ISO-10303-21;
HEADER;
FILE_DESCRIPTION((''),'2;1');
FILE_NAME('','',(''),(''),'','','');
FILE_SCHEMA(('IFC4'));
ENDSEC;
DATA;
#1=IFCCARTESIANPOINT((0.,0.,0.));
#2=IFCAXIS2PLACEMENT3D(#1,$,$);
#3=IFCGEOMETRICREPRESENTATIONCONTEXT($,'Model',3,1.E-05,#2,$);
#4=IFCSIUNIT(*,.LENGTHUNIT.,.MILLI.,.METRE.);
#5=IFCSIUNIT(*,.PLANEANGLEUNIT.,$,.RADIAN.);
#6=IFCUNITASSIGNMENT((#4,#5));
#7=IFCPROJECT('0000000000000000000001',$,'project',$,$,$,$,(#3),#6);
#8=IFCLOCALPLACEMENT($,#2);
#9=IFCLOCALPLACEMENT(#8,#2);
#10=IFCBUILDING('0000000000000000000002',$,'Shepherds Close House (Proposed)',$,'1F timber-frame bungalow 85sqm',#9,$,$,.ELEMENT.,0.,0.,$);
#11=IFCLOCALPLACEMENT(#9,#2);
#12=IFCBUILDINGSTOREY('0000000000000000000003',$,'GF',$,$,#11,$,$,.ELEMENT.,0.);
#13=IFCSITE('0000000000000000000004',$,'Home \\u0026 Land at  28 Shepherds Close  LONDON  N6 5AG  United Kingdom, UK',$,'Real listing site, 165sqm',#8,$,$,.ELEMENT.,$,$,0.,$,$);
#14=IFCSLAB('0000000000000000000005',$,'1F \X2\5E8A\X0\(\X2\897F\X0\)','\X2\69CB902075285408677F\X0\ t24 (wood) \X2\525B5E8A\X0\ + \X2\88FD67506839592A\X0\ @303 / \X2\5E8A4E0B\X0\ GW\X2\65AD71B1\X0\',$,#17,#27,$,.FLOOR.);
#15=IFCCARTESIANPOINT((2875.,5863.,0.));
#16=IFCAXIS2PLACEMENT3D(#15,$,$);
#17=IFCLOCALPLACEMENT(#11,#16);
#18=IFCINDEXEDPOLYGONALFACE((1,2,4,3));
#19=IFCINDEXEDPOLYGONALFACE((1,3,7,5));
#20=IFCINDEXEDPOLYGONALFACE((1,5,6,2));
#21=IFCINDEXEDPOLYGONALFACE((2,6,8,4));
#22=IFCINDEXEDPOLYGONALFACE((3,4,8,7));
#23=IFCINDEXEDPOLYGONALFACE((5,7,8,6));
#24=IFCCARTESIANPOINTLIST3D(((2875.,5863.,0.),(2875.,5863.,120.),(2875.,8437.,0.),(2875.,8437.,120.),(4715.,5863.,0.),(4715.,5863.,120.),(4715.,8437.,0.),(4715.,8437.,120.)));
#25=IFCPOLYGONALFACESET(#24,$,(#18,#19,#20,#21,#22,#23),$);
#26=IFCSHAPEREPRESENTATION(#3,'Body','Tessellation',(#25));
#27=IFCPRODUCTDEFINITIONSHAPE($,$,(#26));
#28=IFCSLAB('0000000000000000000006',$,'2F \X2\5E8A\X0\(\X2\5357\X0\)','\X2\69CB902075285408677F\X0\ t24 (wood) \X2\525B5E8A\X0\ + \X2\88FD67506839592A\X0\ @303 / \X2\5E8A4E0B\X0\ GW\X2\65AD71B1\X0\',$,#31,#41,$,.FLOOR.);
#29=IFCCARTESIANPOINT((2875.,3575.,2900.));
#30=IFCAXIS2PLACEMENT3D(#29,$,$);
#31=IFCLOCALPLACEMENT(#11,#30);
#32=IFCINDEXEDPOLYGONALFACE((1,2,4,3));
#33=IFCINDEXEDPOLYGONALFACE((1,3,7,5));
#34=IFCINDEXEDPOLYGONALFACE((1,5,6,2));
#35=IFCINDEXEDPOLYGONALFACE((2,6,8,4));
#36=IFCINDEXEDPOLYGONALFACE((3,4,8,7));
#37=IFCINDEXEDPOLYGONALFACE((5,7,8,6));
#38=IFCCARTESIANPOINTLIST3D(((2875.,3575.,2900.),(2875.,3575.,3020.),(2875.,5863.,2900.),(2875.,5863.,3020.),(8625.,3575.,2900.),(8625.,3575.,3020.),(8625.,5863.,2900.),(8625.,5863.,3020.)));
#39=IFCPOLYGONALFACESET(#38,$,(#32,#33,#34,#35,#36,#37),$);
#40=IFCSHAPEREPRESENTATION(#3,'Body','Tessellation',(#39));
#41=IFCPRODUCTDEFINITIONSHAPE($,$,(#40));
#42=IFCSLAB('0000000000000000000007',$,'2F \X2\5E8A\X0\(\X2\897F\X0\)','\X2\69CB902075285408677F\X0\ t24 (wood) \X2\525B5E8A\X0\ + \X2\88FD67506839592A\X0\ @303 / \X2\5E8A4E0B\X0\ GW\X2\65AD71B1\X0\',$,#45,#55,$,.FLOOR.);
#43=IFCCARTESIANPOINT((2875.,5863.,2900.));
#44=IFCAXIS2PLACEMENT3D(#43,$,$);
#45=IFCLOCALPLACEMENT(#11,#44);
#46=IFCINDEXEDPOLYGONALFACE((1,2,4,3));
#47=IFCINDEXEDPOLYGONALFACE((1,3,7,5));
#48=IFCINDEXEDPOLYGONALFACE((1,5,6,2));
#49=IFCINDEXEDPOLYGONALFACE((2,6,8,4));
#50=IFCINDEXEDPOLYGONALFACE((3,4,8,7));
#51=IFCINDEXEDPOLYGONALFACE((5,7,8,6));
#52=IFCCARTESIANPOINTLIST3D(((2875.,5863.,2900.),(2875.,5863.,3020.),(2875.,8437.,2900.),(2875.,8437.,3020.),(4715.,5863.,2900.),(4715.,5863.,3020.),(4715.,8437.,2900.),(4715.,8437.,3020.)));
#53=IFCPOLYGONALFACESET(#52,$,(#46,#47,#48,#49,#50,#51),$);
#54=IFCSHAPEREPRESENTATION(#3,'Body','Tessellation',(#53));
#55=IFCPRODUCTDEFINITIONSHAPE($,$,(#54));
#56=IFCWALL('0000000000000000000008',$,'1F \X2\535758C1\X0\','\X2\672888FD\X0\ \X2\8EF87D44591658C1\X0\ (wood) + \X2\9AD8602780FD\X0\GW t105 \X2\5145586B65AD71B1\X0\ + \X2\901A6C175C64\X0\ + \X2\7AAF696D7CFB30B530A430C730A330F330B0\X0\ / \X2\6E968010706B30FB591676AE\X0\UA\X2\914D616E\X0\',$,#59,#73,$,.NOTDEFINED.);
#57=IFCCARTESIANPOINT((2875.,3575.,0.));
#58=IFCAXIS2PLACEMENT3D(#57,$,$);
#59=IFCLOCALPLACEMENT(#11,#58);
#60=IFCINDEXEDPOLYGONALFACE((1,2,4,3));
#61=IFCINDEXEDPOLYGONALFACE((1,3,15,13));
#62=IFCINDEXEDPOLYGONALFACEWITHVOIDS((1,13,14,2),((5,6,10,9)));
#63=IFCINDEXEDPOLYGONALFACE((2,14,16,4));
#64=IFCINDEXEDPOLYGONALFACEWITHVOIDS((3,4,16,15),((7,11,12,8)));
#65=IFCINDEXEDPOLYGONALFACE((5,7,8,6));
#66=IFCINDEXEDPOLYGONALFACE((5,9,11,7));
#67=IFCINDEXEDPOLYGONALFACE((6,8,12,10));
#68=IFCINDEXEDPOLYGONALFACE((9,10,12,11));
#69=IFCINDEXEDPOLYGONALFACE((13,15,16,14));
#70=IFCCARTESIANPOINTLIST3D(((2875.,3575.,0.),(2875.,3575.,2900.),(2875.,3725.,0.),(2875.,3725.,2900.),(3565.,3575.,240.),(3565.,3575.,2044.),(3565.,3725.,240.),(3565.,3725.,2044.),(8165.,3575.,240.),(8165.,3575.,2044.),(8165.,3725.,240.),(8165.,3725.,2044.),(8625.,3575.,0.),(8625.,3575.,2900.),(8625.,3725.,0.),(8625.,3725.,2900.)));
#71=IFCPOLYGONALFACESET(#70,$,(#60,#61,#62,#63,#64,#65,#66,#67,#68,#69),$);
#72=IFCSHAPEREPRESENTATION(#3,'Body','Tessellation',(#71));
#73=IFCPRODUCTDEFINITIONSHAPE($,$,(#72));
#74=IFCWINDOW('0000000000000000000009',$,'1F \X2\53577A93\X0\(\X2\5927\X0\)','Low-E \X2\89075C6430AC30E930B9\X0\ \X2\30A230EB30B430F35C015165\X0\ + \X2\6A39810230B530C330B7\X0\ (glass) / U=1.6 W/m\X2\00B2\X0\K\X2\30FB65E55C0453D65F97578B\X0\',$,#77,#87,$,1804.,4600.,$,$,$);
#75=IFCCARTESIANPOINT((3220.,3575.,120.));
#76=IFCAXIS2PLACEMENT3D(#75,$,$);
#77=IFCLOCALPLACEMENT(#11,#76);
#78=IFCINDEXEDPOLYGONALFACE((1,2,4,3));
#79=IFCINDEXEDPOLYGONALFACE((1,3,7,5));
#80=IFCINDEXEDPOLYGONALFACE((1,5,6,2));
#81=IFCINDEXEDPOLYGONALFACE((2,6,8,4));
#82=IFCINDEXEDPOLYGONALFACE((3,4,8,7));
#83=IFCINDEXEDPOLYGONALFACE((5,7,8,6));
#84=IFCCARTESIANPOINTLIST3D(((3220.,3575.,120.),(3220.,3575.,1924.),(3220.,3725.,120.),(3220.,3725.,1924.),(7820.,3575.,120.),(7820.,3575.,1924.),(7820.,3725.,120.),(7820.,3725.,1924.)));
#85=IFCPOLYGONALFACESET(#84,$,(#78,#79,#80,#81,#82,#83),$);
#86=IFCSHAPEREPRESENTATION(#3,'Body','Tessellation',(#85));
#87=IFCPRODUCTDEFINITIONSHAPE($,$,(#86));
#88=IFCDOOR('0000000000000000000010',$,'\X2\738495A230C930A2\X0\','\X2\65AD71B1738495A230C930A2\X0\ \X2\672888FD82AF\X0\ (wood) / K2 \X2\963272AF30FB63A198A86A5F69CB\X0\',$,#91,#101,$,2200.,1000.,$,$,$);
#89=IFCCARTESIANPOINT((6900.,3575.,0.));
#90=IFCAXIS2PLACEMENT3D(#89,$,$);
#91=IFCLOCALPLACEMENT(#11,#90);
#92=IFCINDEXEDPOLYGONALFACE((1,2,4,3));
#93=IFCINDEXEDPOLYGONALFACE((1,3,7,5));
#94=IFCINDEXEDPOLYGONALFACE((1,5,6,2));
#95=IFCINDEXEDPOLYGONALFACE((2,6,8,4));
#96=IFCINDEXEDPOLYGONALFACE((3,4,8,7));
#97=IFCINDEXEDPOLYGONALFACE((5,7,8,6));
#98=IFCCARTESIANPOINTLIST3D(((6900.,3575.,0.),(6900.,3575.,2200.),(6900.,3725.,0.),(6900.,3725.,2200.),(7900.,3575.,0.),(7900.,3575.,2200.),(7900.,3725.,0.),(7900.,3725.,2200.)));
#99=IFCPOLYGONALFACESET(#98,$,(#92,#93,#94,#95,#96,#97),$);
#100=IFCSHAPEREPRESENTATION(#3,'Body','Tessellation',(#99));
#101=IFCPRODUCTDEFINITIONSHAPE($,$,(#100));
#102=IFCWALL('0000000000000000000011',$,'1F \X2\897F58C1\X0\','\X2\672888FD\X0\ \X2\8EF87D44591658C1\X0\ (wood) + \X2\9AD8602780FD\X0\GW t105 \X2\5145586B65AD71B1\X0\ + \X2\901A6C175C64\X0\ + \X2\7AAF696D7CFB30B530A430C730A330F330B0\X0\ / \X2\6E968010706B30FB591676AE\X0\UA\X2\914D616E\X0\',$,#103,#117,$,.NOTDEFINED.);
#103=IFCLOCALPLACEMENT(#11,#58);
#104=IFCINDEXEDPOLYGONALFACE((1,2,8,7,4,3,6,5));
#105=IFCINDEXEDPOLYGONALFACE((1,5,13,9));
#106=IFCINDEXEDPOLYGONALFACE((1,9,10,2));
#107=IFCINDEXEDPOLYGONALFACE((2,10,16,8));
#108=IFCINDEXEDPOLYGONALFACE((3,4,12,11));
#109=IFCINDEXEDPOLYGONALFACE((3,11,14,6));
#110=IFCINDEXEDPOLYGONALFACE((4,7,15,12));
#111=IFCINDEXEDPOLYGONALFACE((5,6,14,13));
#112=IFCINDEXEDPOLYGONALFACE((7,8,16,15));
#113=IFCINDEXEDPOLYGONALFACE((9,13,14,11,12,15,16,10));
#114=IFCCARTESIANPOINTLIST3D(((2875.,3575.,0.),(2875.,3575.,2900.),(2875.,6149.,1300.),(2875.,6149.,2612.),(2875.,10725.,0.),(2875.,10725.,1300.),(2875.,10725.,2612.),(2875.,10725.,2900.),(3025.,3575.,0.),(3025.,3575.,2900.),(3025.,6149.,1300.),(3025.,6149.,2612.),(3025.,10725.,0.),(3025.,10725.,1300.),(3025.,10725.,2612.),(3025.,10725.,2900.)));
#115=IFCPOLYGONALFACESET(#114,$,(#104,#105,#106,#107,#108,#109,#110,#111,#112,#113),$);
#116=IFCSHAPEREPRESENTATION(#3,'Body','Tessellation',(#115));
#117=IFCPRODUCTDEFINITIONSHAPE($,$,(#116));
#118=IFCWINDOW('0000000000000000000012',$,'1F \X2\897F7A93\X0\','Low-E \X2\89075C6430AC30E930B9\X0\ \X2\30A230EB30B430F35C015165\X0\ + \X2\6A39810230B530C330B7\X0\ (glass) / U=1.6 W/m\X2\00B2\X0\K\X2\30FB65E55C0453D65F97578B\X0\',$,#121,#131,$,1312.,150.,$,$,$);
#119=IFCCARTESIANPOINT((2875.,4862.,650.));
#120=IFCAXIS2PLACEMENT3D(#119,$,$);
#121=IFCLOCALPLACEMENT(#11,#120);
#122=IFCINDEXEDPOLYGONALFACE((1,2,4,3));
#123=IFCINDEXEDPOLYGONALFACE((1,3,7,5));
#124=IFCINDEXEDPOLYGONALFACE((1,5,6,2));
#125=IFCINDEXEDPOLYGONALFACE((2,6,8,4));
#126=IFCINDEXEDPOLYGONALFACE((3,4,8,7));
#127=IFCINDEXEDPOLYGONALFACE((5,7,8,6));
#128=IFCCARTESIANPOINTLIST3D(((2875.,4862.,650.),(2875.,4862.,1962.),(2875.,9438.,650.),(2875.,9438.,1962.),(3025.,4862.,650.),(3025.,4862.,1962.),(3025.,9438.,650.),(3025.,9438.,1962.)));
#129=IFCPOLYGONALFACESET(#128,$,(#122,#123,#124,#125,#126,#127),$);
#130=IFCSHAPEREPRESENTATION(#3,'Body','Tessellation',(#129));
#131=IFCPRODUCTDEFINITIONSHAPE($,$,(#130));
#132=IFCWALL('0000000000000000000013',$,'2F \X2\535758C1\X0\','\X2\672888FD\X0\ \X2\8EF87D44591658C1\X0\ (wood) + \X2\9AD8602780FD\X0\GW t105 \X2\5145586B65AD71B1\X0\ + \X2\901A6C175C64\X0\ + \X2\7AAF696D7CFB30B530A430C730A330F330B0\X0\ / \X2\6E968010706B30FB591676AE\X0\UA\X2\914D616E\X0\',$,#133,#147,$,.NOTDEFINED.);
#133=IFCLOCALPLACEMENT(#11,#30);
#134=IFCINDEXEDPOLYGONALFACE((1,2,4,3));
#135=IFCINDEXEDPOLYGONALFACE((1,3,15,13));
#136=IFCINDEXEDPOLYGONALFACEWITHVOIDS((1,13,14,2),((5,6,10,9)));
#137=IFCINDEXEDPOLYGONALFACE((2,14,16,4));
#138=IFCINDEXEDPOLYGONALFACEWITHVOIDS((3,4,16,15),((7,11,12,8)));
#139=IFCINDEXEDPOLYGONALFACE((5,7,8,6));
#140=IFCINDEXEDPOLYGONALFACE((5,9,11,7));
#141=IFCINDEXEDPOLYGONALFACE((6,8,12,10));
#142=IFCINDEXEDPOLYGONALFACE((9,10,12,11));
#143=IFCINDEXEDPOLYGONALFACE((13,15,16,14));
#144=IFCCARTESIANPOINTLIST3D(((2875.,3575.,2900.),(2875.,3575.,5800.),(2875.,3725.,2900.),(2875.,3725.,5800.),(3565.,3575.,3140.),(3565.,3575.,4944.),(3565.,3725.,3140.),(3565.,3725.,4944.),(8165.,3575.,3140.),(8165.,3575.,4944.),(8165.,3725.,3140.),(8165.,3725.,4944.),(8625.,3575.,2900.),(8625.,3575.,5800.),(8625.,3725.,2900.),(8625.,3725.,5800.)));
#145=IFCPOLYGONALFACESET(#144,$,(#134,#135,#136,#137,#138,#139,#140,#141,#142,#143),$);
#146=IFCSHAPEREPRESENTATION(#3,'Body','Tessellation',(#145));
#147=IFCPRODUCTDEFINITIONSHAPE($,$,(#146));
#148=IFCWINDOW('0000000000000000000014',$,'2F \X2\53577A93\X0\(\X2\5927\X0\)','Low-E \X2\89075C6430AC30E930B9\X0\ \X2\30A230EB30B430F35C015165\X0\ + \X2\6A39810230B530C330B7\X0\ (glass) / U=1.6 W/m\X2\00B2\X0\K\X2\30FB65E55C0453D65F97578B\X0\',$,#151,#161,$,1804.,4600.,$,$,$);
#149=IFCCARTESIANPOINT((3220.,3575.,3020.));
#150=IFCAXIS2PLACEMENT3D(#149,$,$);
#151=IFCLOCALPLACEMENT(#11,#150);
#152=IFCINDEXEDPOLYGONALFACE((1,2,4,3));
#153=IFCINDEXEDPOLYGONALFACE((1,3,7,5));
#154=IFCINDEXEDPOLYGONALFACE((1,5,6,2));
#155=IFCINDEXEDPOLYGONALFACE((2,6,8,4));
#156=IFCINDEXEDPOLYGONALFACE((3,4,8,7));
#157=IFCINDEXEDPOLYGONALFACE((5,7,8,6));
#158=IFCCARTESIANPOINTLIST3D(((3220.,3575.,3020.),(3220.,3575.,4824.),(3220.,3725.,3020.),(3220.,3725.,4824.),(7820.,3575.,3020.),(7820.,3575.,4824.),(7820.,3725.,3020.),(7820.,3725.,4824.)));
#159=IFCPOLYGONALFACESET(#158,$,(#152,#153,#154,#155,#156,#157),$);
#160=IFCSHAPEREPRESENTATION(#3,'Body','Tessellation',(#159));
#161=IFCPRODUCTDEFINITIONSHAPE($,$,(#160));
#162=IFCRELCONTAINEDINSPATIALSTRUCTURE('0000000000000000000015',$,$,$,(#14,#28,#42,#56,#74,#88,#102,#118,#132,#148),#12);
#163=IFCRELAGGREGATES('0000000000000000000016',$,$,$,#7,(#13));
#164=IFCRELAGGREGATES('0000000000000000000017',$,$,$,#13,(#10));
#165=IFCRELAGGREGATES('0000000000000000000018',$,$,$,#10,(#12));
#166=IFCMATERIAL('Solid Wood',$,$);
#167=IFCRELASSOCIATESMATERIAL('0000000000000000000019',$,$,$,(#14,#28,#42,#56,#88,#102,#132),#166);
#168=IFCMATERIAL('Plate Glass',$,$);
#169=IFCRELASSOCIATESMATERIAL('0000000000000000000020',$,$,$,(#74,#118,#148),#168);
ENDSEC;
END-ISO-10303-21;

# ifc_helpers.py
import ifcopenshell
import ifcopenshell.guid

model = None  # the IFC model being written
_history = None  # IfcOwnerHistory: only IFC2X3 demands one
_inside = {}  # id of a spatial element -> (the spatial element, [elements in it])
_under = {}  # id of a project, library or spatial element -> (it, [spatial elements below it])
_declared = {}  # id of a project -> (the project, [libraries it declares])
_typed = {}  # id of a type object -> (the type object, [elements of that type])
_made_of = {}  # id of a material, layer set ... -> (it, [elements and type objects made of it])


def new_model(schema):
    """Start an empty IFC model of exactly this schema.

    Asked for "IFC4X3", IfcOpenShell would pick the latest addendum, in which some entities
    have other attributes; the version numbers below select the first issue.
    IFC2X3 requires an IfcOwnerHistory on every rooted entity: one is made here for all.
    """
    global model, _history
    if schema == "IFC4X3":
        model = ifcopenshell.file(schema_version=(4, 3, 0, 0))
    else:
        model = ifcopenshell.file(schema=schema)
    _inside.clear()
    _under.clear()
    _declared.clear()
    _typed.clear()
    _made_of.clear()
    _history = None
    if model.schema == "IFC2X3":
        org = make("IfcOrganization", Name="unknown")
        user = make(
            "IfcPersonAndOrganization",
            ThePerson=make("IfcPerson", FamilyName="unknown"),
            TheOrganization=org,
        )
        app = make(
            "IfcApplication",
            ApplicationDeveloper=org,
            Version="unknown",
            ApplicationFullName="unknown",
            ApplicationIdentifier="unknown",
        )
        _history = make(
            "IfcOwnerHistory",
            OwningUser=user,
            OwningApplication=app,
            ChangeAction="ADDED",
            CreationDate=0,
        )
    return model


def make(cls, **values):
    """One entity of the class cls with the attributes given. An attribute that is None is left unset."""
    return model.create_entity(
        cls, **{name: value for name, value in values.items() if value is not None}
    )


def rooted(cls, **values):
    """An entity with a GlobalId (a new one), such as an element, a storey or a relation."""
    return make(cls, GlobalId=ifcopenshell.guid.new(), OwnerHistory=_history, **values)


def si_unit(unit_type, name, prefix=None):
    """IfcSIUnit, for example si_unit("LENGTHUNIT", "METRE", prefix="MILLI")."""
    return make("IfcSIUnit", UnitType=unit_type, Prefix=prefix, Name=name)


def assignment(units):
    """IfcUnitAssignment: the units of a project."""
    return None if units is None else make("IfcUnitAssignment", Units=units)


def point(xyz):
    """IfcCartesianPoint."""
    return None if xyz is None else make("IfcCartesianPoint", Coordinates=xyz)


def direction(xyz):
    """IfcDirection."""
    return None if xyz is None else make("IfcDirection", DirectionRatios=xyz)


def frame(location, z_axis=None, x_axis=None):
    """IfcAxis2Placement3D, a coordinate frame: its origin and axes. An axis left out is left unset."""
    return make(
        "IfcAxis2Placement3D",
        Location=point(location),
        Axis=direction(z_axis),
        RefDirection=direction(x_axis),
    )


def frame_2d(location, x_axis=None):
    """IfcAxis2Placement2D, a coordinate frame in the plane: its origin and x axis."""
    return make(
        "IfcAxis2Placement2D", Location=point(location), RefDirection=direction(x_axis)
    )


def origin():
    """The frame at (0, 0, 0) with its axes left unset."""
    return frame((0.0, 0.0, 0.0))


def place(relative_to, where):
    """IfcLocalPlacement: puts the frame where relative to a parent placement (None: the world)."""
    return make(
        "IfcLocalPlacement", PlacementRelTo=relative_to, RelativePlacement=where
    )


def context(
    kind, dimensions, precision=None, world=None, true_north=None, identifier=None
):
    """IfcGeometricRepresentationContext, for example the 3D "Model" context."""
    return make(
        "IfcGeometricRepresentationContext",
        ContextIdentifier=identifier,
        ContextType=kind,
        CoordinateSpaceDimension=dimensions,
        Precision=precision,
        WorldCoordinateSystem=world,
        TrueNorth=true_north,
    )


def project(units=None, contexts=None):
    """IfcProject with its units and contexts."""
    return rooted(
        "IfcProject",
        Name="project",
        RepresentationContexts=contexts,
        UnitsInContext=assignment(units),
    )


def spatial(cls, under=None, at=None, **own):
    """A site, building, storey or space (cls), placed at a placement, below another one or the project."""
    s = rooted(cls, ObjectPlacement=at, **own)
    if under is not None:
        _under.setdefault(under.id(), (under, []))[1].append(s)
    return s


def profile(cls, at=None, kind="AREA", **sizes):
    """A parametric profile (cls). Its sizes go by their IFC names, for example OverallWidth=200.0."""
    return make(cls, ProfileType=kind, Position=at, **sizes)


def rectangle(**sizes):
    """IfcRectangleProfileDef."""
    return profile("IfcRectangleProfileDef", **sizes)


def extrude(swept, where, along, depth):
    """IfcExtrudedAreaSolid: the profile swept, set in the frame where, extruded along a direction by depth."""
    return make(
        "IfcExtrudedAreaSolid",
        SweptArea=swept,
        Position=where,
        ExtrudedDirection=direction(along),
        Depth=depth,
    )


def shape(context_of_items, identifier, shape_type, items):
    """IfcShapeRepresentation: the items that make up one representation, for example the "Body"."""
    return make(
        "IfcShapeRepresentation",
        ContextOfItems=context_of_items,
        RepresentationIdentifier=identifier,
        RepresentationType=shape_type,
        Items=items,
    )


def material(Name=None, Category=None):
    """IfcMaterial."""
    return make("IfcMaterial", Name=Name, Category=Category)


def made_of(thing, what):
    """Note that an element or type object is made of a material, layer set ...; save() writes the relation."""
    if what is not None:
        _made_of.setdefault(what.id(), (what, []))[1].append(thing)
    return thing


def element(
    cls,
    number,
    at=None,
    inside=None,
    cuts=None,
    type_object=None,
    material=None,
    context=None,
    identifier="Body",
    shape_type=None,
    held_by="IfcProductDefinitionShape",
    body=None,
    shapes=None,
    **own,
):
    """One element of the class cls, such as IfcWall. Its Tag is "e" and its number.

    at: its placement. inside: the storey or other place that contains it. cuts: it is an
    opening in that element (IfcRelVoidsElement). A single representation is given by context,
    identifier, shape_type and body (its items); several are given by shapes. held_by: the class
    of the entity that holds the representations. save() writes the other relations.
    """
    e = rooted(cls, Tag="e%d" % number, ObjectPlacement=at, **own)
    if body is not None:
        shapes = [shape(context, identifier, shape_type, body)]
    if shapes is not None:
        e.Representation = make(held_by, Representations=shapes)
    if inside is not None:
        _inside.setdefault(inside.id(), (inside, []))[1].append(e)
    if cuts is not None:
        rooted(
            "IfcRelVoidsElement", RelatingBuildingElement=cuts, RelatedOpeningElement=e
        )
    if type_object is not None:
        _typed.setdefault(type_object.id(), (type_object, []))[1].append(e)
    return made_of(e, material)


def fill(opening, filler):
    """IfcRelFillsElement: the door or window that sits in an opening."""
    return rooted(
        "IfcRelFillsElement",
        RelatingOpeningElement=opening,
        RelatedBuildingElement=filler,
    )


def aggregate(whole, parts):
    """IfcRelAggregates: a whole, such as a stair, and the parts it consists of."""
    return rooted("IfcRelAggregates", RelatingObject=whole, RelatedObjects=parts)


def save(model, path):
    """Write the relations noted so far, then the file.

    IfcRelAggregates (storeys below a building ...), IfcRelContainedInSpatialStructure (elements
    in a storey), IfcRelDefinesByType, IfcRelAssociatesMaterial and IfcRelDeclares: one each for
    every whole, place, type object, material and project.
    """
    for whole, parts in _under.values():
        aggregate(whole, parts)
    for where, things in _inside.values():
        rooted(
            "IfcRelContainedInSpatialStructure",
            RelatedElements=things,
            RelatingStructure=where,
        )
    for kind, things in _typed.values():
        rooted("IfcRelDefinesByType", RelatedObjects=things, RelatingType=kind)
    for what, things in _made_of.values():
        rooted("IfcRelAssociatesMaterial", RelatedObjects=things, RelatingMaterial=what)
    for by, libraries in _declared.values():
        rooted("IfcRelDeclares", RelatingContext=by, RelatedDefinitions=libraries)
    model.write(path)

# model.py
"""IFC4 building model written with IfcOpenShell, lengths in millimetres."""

from ifc_helpers import new_model, si_unit, frame, frame_2d, origin, place, context, project, spatial, rectangle, extrude, material, element, fill, save


model = new_model("IFC4")

# Units and contexts
model_context = context("Model", 3, precision=1e-05, world=origin())
ifc_project = project(units=[si_unit("LENGTHUNIT", "METRE", prefix="MILLI"), si_unit("PLANEANGLEUNIT", "RADIAN")], contexts=[model_context])

# Site, building, storey
site_placement = place(None, origin())
site = spatial("IfcSite", under=ifc_project, at=site_placement, Name="Home \\u0026 Land at  28 Shepherds Close  LONDON  N6 5AG  United Kingdom, UK", ObjectType="Real listing site, 165sqm", CompositionType="ELEMENT", RefElevation=0.0)
building_placement = place(site_placement, origin())
building = spatial("IfcBuilding", under=site, at=building_placement, Name="Shepherds Close House (Proposed)", ObjectType="1F timber-frame bungalow 85sqm", CompositionType="ELEMENT", ElevationOfRefHeight=0.0, ElevationOfTerrain=0.0)
storey_placement = place(building_placement, origin())
storey = spatial("IfcBuildingStorey", under=building, at=storey_placement, Name="GF", CompositionType="ELEMENT", Elevation=0.0)

# Slabs
ifc_material_1 = material(Name="Solid Wood")
slab_1_placement = place(storey_placement, frame((2875.0, 5863.0, 0.0)))
element("IfcSlab", 1, at=slab_1_placement, inside=storey, material=ifc_material_1, Name="1F 床(西)", Description="構造用合板 t24 (wood) 剛床 + 製材根太 @303 / 床下 GW断熱", PredefinedType="FLOOR", context=model_context, shape_type="SweptSolid", body=[
    extrude(rectangle(XDim=1840.0, YDim=2574.0, at=frame_2d((920.0, 1287.0))), frame((2875.0, 5863.0, 0.0)), (0.0, 0.0, 1.0), 120.0),
])
slab_2_placement = place(storey_placement, frame((2875.0, 3575.0, 2900.0)))
element("IfcSlab", 2, at=slab_2_placement, inside=storey, material=ifc_material_1, Name="2F 床(南)", Description="構造用合板 t24 (wood) 剛床 + 製材根太 @303 / 床下 GW断熱", PredefinedType="FLOOR", context=model_context, shape_type="SweptSolid", body=[
    extrude(rectangle(XDim=5750.0, YDim=2288.0, at=frame_2d((2875.0, 1144.0))), frame((2875.0, 3575.0, 2900.0)), (0.0, 0.0, 1.0), 120.0),
])
slab_3_placement = place(storey_placement, frame((2875.0, 5863.0, 2900.0)))
element("IfcSlab", 3, at=slab_3_placement, inside=storey, material=ifc_material_1, Name="2F 床(西)", Description="構造用合板 t24 (wood) 剛床 + 製材根太 @303 / 床下 GW断熱", PredefinedType="FLOOR", context=model_context, shape_type="SweptSolid", body=[
    extrude(rectangle(XDim=1840.0, YDim=2574.0, at=frame_2d((920.0, 1287.0))), frame((2875.0, 5863.0, 2900.0)), (0.0, 0.0, 1.0), 120.0),
])

# Wall, openings, window, door
wall_1_placement = place(storey_placement, frame((2875.0, 3575.0, 0.0)))
wall_1 = element("IfcWall", 4, at=wall_1_placement, inside=storey, material=ifc_material_1, Name="1F 南壁", Description="木製 軸組外壁 (wood) + 高性能GW t105 充填断熱 + 通気層 + 窯業系サイディング / 準耐火・外皮UA配慮", PredefinedType="NOTDEFINED", context=model_context, shape_type="SweptSolid", body=[
    extrude(rectangle(XDim=5750.0, YDim=150.0, at=frame_2d((2875.0, 75.0))), frame((2875.0, 3575.0, 0.0)), (0.0, 0.0, 1.0), 2900.0),
])
opening_1_placement = place(storey_placement, frame((3220.0, 3575.0, 120.0)))
opening_1 = element("IfcOpeningElement", 5, at=opening_1_placement, cuts=wall_1, PredefinedType="NOTDEFINED", context=model_context, shape_type="SweptSolid", body=[
    extrude(rectangle(XDim=4600.0, YDim=150.0, at=frame_2d((2300.0, 75.0))), frame((3220.0, 3575.0, 120.0)), (0.0, 0.0, 1.0), 1804.0),
])
opening_2_placement = place(storey_placement, frame((6900.0, 3575.0, 0.0)))
opening_2 = element("IfcOpeningElement", 6, at=opening_2_placement, cuts=wall_1, PredefinedType="NOTDEFINED", context=model_context, shape_type="SweptSolid", body=[
    extrude(rectangle(XDim=1000.0, YDim=150.0, at=frame_2d((500.0, 75.0))), frame((6900.0, 3575.0, 0.0)), (0.0, 0.0, 1.0), 2200.0),
])
ifc_material_2 = material(Name="Plate Glass")
window_1_placement = place(storey_placement, frame((3220.0, 3575.0, 120.0)))
window_1 = element("IfcWindow", 7, at=window_1_placement, inside=storey, material=ifc_material_2, Name="1F 南窓(大)", Description="Low-E 複層ガラス アルゴン封入 + 樹脂サッシ (glass) / U=1.6 W/m²K・日射取得型", OverallHeight=1804.0, OverallWidth=4600.0, context=model_context, shape_type="SweptSolid", body=[
    extrude(rectangle(XDim=4600.0, YDim=150.0, at=frame_2d((2300.0, 75.0))), frame((3220.0, 3575.0, 120.0)), (0.0, 0.0, 1.0), 1804.0),
])
fill(opening_1, window_1)
door_placement = place(storey_placement, frame((6900.0, 3575.0, 0.0)))
door = element("IfcDoor", 8, at=door_placement, inside=storey, material=ifc_material_1, Name="玄関ドア", Description="断熱玄関ドア 木製芯 (wood) / K2 防犯・採風機構", OverallHeight=2200.0, OverallWidth=1000.0, context=model_context, shape_type="SweptSolid", body=[
    extrude(rectangle(XDim=1000.0, YDim=150.0, at=frame_2d((500.0, 75.0))), frame((6900.0, 3575.0, 0.0)), (0.0, 0.0, 1.0), 2200.0),
])
fill(opening_2, door)

# Walls, openings, windows
wall_2_placement = place(storey_placement, frame((2875.0, 3575.0, 0.0)))
wall_2 = element("IfcWall", 9, at=wall_2_placement, inside=storey, material=ifc_material_1, Name="1F 西壁", Description="木製 軸組外壁 (wood) + 高性能GW t105 充填断熱 + 通気層 + 窯業系サイディング / 準耐火・外皮UA配慮", PredefinedType="NOTDEFINED", context=model_context, shape_type="SweptSolid", body=[
    extrude(rectangle(XDim=150.0, YDim=7150.0, at=frame_2d((75.0, 3575.0))), frame((2875.0, 3575.0, 0.0)), (0.0, 0.0, 1.0), 2900.0),
])
opening_3_placement = place(storey_placement, frame((2875.0, 4862.0, 650.0)))
opening_3 = element("IfcOpeningElement", 10, at=opening_3_placement, cuts=wall_2, PredefinedType="NOTDEFINED", context=model_context, shape_type="SweptSolid", body=[
    extrude(rectangle(XDim=150.0, YDim=4576.0, at=frame_2d((75.0, 2288.0))), frame((2875.0, 4862.0, 650.0)), (0.0, 0.0, 1.0), 1312.0),
])
window_2_placement = place(storey_placement, frame((2875.0, 4862.0, 650.0)))
window_2 = element("IfcWindow", 11, at=window_2_placement, inside=storey, material=ifc_material_2, Name="1F 西窓", Description="Low-E 複層ガラス アルゴン封入 + 樹脂サッシ (glass) / U=1.6 W/m²K・日射取得型", OverallHeight=1312.0, OverallWidth=150.0, context=model_context, shape_type="SweptSolid", body=[
    extrude(rectangle(XDim=150.0, YDim=4576.0, at=frame_2d((75.0, 2288.0))), frame((2875.0, 4862.0, 650.0)), (0.0, 0.0, 1.0), 1312.0),
])
fill(opening_3, window_2)
wall_3_placement = place(storey_placement, frame((2875.0, 3575.0, 2900.0)))
wall_3 = element("IfcWall", 12, at=wall_3_placement, inside=storey, material=ifc_material_1, Name="2F 南壁", Description="木製 軸組外壁 (wood) + 高性能GW t105 充填断熱 + 通気層 + 窯業系サイディング / 準耐火・外皮UA配慮", PredefinedType="NOTDEFINED", context=model_context, shape_type="SweptSolid", body=[
    extrude(rectangle(XDim=5750.0, YDim=150.0, at=frame_2d((2875.0, 75.0))), frame((2875.0, 3575.0, 2900.0)), (0.0, 0.0, 1.0), 2900.0),
])
opening_4_placement = place(storey_placement, frame((3220.0, 3575.0, 3020.0)))
opening_4 = element("IfcOpeningElement", 13, at=opening_4_placement, cuts=wall_3, PredefinedType="NOTDEFINED", context=model_context, shape_type="SweptSolid", body=[
    extrude(rectangle(XDim=4600.0, YDim=150.0, at=frame_2d((2300.0, 75.0))), frame((3220.0, 3575.0, 3020.0)), (0.0, 0.0, 1.0), 1804.0),
])
window_3_placement = place(storey_placement, frame((3220.0, 3575.0, 3020.0)))
window_3 = element("IfcWindow", 14, at=window_3_placement, inside=storey, material=ifc_material_2, Name="2F 南窓(大)", Description="Low-E 複層ガラス アルゴン封入 + 樹脂サッシ (glass) / U=1.6 W/m²K・日射取得型", OverallHeight=1804.0, OverallWidth=4600.0, context=model_context, shape_type="SweptSolid", body=[
    extrude(rectangle(XDim=4600.0, YDim=150.0, at=frame_2d((2300.0, 75.0))), frame((3220.0, 3575.0, 3020.0)), (0.0, 0.0, 1.0), 1804.0),
])
fill(opening_4, window_3)

save(model, "model.ifc")
